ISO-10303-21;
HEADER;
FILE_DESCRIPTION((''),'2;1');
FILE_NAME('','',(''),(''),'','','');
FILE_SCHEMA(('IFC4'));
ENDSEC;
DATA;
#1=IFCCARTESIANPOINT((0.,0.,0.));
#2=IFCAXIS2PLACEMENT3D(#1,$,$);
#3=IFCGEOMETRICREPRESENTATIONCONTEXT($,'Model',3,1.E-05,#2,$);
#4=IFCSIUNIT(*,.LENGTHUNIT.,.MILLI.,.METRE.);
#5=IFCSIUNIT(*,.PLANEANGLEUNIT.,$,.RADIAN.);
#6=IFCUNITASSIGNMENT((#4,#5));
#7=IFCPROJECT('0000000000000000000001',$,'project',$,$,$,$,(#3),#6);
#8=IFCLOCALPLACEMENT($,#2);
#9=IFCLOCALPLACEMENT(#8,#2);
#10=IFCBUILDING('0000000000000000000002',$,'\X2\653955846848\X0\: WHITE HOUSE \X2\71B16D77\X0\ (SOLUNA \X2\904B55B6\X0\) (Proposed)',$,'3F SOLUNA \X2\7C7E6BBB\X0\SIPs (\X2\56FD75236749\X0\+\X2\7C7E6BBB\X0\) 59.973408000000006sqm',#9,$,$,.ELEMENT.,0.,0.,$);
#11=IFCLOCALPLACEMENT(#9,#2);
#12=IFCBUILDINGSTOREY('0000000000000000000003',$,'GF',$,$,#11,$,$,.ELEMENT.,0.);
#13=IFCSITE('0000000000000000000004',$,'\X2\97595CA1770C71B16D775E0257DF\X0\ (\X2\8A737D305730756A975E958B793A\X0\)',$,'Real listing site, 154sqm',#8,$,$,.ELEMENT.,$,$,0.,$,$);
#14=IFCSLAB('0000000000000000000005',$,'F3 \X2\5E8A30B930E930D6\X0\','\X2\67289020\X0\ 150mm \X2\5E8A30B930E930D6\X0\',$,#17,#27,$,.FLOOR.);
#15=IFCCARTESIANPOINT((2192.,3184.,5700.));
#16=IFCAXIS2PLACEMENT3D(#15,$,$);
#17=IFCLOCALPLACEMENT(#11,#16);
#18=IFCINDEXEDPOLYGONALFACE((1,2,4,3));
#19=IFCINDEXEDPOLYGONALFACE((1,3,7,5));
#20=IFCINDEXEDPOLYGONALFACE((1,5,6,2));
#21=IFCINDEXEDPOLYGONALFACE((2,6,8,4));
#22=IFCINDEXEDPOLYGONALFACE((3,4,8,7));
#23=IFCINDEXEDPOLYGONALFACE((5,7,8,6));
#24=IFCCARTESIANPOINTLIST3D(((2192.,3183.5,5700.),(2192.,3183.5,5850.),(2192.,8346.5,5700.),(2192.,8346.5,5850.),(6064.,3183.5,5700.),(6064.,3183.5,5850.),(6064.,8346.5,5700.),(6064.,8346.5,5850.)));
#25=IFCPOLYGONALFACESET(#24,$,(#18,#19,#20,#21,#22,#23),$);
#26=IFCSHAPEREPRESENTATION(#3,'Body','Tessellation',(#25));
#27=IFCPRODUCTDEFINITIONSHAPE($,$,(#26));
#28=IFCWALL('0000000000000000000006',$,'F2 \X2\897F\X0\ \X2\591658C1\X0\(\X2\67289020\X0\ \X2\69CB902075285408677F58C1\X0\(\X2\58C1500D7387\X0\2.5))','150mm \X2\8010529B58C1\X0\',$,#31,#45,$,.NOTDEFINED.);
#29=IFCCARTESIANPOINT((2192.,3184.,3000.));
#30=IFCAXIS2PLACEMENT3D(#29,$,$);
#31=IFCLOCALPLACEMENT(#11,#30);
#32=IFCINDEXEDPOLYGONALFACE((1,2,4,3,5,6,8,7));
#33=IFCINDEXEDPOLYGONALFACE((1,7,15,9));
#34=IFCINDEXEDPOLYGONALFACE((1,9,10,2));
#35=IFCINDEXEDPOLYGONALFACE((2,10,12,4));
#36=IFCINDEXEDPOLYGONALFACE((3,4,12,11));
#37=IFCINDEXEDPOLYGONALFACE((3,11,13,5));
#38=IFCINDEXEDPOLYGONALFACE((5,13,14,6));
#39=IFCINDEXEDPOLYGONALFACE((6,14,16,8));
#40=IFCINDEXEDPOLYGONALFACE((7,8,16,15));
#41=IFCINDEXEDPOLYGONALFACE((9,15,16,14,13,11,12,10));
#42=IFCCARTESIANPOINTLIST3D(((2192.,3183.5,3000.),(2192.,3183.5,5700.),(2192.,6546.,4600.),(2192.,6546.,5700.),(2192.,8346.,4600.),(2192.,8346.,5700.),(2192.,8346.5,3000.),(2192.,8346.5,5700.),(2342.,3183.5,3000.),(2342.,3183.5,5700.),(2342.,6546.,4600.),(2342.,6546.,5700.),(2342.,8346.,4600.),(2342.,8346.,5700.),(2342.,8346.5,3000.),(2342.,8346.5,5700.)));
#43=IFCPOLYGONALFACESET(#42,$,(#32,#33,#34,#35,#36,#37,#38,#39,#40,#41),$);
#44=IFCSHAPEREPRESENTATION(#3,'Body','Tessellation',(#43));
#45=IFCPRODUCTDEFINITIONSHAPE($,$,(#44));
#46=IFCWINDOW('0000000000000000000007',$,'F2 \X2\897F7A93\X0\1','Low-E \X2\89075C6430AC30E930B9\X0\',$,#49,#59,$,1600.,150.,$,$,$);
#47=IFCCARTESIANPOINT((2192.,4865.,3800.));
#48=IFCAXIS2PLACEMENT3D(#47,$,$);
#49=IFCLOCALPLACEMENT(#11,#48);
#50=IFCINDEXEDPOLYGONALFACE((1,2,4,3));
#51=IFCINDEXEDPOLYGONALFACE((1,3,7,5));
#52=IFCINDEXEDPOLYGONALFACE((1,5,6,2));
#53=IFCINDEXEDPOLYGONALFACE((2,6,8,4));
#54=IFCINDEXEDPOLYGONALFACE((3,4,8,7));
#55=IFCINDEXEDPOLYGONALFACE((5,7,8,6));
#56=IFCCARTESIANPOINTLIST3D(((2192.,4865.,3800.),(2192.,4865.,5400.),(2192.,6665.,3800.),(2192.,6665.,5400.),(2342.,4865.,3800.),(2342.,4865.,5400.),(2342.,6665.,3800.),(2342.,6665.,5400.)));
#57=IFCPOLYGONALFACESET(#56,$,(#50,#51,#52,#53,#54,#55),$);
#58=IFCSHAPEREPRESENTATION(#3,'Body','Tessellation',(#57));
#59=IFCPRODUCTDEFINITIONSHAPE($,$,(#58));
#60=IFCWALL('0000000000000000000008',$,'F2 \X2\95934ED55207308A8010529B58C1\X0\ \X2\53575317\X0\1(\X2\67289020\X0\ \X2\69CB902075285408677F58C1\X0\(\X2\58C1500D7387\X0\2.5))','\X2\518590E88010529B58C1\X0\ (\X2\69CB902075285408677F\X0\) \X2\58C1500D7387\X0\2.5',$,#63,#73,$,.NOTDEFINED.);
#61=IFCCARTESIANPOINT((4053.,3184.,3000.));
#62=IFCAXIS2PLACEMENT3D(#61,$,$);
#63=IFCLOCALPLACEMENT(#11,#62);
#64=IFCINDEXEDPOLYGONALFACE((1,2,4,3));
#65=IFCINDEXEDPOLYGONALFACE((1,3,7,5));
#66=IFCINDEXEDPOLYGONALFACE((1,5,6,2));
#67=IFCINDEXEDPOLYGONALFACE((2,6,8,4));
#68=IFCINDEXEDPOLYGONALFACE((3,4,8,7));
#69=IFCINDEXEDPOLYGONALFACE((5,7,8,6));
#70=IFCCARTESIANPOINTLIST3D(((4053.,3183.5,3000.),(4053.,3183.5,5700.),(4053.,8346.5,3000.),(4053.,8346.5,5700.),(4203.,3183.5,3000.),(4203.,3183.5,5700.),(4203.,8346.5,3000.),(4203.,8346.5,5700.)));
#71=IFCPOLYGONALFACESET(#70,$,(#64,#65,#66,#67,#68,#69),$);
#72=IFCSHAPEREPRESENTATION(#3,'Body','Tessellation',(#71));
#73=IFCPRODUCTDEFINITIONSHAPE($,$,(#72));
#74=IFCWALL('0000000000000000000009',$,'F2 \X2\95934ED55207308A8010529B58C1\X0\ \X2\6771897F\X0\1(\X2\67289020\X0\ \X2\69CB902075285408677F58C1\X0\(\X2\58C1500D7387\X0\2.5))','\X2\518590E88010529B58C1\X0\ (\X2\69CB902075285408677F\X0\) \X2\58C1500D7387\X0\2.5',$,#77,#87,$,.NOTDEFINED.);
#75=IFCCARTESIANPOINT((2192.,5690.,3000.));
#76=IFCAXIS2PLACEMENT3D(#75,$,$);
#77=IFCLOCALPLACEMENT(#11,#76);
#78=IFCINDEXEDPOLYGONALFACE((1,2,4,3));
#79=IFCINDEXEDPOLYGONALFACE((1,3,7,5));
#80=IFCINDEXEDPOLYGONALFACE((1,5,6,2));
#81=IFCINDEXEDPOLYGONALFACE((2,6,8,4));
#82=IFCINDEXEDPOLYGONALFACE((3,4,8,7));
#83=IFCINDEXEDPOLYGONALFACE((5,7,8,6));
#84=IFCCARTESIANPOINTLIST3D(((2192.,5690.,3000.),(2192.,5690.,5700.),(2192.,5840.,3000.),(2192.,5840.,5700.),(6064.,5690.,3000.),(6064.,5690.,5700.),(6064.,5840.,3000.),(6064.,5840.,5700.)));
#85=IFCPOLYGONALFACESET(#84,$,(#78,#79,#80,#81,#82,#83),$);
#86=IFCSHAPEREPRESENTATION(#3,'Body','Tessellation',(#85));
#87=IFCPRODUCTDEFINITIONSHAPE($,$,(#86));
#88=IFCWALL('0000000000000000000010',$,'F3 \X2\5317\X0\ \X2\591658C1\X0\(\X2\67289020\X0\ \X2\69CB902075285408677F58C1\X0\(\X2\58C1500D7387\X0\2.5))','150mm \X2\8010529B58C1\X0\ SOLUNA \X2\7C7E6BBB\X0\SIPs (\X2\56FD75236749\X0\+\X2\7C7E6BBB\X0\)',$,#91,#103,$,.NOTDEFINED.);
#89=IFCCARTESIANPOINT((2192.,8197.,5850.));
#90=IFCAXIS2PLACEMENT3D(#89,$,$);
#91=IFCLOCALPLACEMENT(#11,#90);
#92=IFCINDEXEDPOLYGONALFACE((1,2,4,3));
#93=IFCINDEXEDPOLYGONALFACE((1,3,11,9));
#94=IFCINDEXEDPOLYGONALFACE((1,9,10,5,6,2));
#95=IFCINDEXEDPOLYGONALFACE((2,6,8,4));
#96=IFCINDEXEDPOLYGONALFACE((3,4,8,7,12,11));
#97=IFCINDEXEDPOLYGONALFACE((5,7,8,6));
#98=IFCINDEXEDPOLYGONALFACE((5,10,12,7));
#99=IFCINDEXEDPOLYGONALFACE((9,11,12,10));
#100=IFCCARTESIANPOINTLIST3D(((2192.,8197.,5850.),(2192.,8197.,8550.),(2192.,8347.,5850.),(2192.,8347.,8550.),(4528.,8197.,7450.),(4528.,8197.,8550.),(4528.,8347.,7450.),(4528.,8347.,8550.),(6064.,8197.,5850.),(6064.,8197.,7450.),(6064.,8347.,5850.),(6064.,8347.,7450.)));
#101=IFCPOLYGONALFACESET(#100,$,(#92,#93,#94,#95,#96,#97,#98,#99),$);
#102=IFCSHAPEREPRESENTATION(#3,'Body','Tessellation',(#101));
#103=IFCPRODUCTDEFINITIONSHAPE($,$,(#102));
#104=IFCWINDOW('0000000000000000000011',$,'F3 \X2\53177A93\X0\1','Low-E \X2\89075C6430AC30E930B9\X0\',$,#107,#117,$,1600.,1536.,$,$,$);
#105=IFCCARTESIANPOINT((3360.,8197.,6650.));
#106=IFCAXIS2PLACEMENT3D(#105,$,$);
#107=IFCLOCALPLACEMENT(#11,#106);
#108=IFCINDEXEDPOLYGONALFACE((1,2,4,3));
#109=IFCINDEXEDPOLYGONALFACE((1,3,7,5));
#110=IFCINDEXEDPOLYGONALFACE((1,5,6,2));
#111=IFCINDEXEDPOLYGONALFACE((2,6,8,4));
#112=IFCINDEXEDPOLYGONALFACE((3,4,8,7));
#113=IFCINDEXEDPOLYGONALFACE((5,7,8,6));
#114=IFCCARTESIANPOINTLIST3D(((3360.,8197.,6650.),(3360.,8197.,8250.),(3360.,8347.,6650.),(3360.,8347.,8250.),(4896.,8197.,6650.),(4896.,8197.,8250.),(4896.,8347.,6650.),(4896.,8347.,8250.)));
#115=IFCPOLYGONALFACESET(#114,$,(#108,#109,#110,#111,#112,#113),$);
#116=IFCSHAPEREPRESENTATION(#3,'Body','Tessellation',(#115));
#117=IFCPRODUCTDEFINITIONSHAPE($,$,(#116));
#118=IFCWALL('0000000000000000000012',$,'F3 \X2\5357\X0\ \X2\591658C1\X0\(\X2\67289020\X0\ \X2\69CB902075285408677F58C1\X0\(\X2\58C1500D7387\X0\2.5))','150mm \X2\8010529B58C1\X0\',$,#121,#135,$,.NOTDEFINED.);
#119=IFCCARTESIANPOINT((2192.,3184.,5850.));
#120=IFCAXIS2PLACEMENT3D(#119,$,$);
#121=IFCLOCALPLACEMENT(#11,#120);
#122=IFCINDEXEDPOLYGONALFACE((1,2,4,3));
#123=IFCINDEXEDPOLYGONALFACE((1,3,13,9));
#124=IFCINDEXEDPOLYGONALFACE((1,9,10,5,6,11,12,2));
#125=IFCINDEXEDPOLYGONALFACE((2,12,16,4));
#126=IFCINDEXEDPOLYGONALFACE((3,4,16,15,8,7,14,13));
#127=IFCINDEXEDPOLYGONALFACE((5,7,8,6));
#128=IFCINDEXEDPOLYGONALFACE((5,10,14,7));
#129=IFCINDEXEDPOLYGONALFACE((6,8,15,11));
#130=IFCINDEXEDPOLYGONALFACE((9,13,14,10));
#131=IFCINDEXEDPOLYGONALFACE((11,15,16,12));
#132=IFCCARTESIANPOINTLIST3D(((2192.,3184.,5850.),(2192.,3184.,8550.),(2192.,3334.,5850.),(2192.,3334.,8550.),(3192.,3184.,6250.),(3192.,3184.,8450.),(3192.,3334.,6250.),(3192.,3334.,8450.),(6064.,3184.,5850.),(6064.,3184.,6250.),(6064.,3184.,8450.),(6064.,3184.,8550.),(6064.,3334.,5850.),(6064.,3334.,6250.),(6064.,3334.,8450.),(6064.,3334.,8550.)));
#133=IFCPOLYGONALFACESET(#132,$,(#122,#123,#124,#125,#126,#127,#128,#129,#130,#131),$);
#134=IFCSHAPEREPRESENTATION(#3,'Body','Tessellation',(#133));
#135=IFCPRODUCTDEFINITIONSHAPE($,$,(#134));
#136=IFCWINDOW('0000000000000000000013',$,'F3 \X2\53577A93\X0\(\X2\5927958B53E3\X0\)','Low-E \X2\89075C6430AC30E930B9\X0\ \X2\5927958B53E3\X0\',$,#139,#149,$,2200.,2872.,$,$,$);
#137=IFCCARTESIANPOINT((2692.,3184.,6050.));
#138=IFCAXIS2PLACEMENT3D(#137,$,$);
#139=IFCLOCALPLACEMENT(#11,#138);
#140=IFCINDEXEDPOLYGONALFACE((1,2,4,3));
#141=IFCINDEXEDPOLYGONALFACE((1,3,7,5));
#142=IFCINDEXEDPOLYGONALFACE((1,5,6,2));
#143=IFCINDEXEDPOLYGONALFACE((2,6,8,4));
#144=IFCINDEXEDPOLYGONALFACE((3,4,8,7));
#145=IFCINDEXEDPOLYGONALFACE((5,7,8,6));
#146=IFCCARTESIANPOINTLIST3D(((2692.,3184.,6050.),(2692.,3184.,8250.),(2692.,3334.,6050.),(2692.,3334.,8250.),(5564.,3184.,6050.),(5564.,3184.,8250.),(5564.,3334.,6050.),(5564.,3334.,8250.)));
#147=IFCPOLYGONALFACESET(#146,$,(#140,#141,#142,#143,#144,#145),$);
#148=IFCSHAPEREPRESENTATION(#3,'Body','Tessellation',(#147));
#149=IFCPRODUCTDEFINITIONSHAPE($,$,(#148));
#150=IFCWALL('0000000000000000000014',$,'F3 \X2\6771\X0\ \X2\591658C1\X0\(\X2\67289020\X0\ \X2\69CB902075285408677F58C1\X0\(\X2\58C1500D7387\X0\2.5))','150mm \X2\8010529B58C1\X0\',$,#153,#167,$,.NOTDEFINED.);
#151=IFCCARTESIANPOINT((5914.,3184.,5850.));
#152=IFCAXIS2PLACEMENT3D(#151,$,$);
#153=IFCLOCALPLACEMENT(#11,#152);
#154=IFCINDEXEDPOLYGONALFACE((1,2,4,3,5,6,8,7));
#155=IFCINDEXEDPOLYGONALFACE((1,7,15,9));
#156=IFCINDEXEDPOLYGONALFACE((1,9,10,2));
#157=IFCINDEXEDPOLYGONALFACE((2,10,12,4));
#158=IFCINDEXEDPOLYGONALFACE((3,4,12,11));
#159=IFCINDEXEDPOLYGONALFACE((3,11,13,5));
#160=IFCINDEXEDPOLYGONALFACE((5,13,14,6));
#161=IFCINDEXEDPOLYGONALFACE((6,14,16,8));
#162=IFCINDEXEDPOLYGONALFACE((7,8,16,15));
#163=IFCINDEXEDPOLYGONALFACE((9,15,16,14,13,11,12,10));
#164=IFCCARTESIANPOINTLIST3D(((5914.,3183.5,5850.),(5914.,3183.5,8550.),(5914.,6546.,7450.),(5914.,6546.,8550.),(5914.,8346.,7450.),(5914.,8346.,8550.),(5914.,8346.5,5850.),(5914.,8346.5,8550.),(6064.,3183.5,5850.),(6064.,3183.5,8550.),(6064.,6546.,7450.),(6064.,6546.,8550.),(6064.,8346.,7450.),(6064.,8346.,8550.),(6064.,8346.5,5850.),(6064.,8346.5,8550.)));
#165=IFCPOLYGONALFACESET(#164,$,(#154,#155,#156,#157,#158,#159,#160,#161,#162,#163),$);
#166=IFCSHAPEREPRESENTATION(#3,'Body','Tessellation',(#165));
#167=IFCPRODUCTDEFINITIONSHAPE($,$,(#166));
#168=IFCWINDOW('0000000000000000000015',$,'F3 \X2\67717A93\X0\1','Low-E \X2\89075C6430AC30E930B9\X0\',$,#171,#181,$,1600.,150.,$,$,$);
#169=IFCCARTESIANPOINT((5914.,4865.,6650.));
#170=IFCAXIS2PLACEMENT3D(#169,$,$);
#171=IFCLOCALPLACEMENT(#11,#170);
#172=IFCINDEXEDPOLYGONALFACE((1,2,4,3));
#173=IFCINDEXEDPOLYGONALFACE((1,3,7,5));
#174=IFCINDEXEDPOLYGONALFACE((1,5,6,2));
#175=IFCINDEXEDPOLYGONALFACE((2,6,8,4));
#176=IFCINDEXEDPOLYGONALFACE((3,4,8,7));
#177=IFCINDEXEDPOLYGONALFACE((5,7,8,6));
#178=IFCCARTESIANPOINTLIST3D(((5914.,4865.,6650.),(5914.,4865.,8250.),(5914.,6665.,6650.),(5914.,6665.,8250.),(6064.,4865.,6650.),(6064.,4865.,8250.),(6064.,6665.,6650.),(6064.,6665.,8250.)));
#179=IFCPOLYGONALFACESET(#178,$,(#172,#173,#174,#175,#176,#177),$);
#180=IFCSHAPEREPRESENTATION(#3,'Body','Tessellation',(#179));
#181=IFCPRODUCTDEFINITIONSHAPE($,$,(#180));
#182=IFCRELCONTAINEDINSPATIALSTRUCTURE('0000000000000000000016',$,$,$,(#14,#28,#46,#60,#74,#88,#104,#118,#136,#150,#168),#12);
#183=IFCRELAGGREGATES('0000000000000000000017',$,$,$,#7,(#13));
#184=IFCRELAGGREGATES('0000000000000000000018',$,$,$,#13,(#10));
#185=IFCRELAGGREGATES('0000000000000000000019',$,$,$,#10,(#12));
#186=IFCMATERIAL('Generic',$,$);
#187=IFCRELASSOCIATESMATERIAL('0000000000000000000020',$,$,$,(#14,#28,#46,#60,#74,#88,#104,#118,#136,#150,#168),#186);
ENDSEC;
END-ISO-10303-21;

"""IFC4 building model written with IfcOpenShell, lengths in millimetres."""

from ifc_helpers import new_model, si_unit, frame, frame_2d, origin, place, context, project, spatial, rectangle, extrude, material, element, fill, save


model = new_model("IFC4")

# Units and contexts
model_context = context("Model", 3, precision=1e-05, world=origin())
ifc_project = project(units=[si_unit("LENGTHUNIT", "METRE", prefix="MILLI"), si_unit("PLANEANGLEUNIT", "RADIAN")], contexts=[model_context])

# Site, building, storey
site_placement = place(None, origin())
site = spatial("IfcSite", under=ifc_project, at=site_placement, Name="静岡県熱海市域 (詳細地番非開示)", ObjectType="Real listing site, 154sqm", CompositionType="ELEMENT", RefElevation=0.0)
building_placement = place(site_placement, origin())
building = spatial("IfcBuilding", under=site, at=building_placement, Name="改善案: WHITE HOUSE 熱海 (SOLUNA 運営) (Proposed)", ObjectType="3F SOLUNA 籾殻SIPs (国産杉+籾殻) 59.973408000000006sqm", CompositionType="ELEMENT", ElevationOfRefHeight=0.0, ElevationOfTerrain=0.0)
storey_placement = place(building_placement, origin())
storey = spatial("IfcBuildingStorey", under=building, at=storey_placement, Name="GF", CompositionType="ELEMENT", Elevation=0.0)

# Slab
ifc_material_1 = material(Name="Generic")
slab_placement = place(storey_placement, frame((2192.0, 3184.0, 5700.0)))
element("IfcSlab", 1, at=slab_placement, inside=storey, material=ifc_material_1, Name="F3 床スラブ", Description="木造 150mm 床スラブ", PredefinedType="FLOOR", context=model_context, shape_type="SweptSolid", body=[
    extrude(rectangle(XDim=3872.0, YDim=5163.0, at=frame_2d((1936.0, 2581.0))), frame((2192.0, 3184.0, 5700.0)), (0.0, 0.0, 1.0), 150.0),
])

# Wall, opening, window
wall_1_placement = place(storey_placement, frame((2192.0, 3184.0, 3000.0)))
wall_1 = element("IfcWall", 2, at=wall_1_placement, inside=storey, material=ifc_material_1, Name="F2 西 外壁(木造 構造用合板壁(壁倍率2.5))", Description="150mm 耐力壁", PredefinedType="NOTDEFINED", context=model_context, shape_type="SweptSolid", body=[
    extrude(rectangle(XDim=150.0, YDim=5163.0, at=frame_2d((75.0, 2581.0))), frame((2192.0, 3184.0, 3000.0)), (0.0, 0.0, 1.0), 2700.0),
])
opening_1_placement = place(storey_placement, frame((2192.0, 4865.0, 3800.0)))
opening_1 = element("IfcOpeningElement", 3, at=opening_1_placement, cuts=wall_1, PredefinedType="NOTDEFINED", context=model_context, shape_type="SweptSolid", body=[
    extrude(rectangle(XDim=150.0, YDim=1800.0, at=frame_2d((75.0, 900.0))), frame((2192.0, 4865.0, 3800.0)), (0.0, 0.0, 1.0), 1600.0),
])
window_1_placement = place(storey_placement, frame((2192.0, 4865.0, 3800.0)))
window_1 = element("IfcWindow", 4, at=window_1_placement, inside=storey, material=ifc_material_1, Name="F2 西窓1", Description="Low-E 複層ガラス", OverallHeight=1600.0, OverallWidth=150.0, context=model_context, shape_type="SweptSolid", body=[
    extrude(rectangle(XDim=150.0, YDim=1800.0, at=frame_2d((75.0, 900.0))), frame((2192.0, 4865.0, 3800.0)), (0.0, 0.0, 1.0), 1600.0),
])
fill(opening_1, window_1)

# Walls
wall_2_placement = place(storey_placement, frame((4053.0, 3184.0, 3000.0)))
element("IfcWall", 5, at=wall_2_placement, inside=storey, material=ifc_material_1, Name="F2 間仕切り耐力壁 南北1(木造 構造用合板壁(壁倍率2.5))", Description="内部耐力壁 (構造用合板) 壁倍率2.5", PredefinedType="NOTDEFINED", context=model_context, shape_type="SweptSolid", body=[
    extrude(rectangle(XDim=150.0, YDim=5163.0, at=frame_2d((75.0, 2581.0))), frame((4053.0, 3184.0, 3000.0)), (0.0, 0.0, 1.0), 2700.0),
])
wall_3_placement = place(storey_placement, frame((2192.0, 5690.0, 3000.0)))
element("IfcWall", 6, at=wall_3_placement, inside=storey, material=ifc_material_1, Name="F2 間仕切り耐力壁 東西1(木造 構造用合板壁(壁倍率2.5))", Description="内部耐力壁 (構造用合板) 壁倍率2.5", PredefinedType="NOTDEFINED", context=model_context, shape_type="SweptSolid", body=[
    extrude(rectangle(XDim=3872.0, YDim=150.0, at=frame_2d((1936.0, 75.0))), frame((2192.0, 5690.0, 3000.0)), (0.0, 0.0, 1.0), 2700.0),
])

# Walls, openings, windows
wall_4_placement = place(storey_placement, frame((2192.0, 8197.0, 5850.0)))
wall_4 = element("IfcWall", 7, at=wall_4_placement, inside=storey, material=ifc_material_1, Name="F3 北 外壁(木造 構造用合板壁(壁倍率2.5))", Description="150mm 耐力壁 SOLUNA 籾殻SIPs (国産杉+籾殻)", PredefinedType="NOTDEFINED", context=model_context, shape_type="SweptSolid", body=[
    extrude(rectangle(XDim=3872.0, YDim=150.0, at=frame_2d((1936.0, 75.0))), frame((2192.0, 8197.0, 5850.0)), (0.0, 0.0, 1.0), 2700.0),
])
opening_2_placement = place(storey_placement, frame((3360.0, 8197.0, 6650.0)))
opening_2 = element("IfcOpeningElement", 8, at=opening_2_placement, cuts=wall_4, PredefinedType="NOTDEFINED", context=model_context, shape_type="SweptSolid", body=[
    extrude(rectangle(XDim=1536.0, YDim=150.0, at=frame_2d((768.0, 75.0))), frame((3360.0, 8197.0, 6650.0)), (0.0, 0.0, 1.0), 1600.0),
])
window_2_placement = place(storey_placement, frame((3360.0, 8197.0, 6650.0)))
window_2 = element("IfcWindow", 9, at=window_2_placement, inside=storey, material=ifc_material_1, Name="F3 北窓1", Description="Low-E 複層ガラス", OverallHeight=1600.0, OverallWidth=1536.0, context=model_context, shape_type="SweptSolid", body=[
    extrude(rectangle(XDim=1536.0, YDim=150.0, at=frame_2d((768.0, 75.0))), frame((3360.0, 8197.0, 6650.0)), (0.0, 0.0, 1.0), 1600.0),
])
fill(opening_2, window_2)
wall_5_placement = place(storey_placement, frame((2192.0, 3184.0, 5850.0)))
wall_5 = element("IfcWall", 10, at=wall_5_placement, inside=storey, material=ifc_material_1, Name="F3 南 外壁(木造 構造用合板壁(壁倍率2.5))", Description="150mm 耐力壁", PredefinedType="NOTDEFINED", context=model_context, shape_type="SweptSolid", body=[
    extrude(rectangle(XDim=3872.0, YDim=150.0, at=frame_2d((1936.0, 75.0))), frame((2192.0, 3184.0, 5850.0)), (0.0, 0.0, 1.0), 2700.0),
])
opening_3_placement = place(storey_placement, frame((2692.0, 3184.0, 6050.0)))
opening_3 = element("IfcOpeningElement", 11, at=opening_3_placement, cuts=wall_5, PredefinedType="NOTDEFINED", context=model_context, shape_type="SweptSolid", body=[
    extrude(rectangle(XDim=2872.0, YDim=150.0, at=frame_2d((1436.0, 75.0))), frame((2692.0, 3184.0, 6050.0)), (0.0, 0.0, 1.0), 2200.0),
])
window_3_placement = place(storey_placement, frame((2692.0, 3184.0, 6050.0)))
window_3 = element("IfcWindow", 12, at=window_3_placement, inside=storey, material=ifc_material_1, Name="F3 南窓(大開口)", Description="Low-E 複層ガラス 大開口", OverallHeight=2200.0, OverallWidth=2872.0, context=model_context, shape_type="SweptSolid", body=[
    extrude(rectangle(XDim=2872.0, YDim=150.0, at=frame_2d((1436.0, 75.0))), frame((2692.0, 3184.0, 6050.0)), (0.0, 0.0, 1.0), 2200.0),
])
fill(opening_3, window_3)
wall_6_placement = place(storey_placement, frame((5914.0, 3184.0, 5850.0)))
wall_6 = element("IfcWall", 13, at=wall_6_placement, inside=storey, material=ifc_material_1, Name="F3 東 外壁(木造 構造用合板壁(壁倍率2.5))", Description="150mm 耐力壁", PredefinedType="NOTDEFINED", context=model_context, shape_type="SweptSolid", body=[
    extrude(rectangle(XDim=150.0, YDim=5163.0, at=frame_2d((75.0, 2581.0))), frame((5914.0, 3184.0, 5850.0)), (0.0, 0.0, 1.0), 2700.0),
])
opening_4_placement = place(storey_placement, frame((5914.0, 4865.0, 6650.0)))
opening_4 = element("IfcOpeningElement", 14, at=opening_4_placement, cuts=wall_6, PredefinedType="NOTDEFINED", context=model_context, shape_type="SweptSolid", body=[
    extrude(rectangle(XDim=150.0, YDim=1800.0, at=frame_2d((75.0, 900.0))), frame((5914.0, 4865.0, 6650.0)), (0.0, 0.0, 1.0), 1600.0),
])
window_4_placement = place(storey_placement, frame((5914.0, 4865.0, 6650.0)))
window_4 = element("IfcWindow", 15, at=window_4_placement, inside=storey, material=ifc_material_1, Name="F3 東窓1", Description="Low-E 複層ガラス", OverallHeight=1600.0, OverallWidth=150.0, context=model_context, shape_type="SweptSolid", body=[
    extrude(rectangle(XDim=150.0, YDim=1800.0, at=frame_2d((75.0, 900.0))), frame((5914.0, 4865.0, 6650.0)), (0.0, 0.0, 1.0), 1600.0),
])
fill(opening_4, window_4)

save(model, "model.ifc")
